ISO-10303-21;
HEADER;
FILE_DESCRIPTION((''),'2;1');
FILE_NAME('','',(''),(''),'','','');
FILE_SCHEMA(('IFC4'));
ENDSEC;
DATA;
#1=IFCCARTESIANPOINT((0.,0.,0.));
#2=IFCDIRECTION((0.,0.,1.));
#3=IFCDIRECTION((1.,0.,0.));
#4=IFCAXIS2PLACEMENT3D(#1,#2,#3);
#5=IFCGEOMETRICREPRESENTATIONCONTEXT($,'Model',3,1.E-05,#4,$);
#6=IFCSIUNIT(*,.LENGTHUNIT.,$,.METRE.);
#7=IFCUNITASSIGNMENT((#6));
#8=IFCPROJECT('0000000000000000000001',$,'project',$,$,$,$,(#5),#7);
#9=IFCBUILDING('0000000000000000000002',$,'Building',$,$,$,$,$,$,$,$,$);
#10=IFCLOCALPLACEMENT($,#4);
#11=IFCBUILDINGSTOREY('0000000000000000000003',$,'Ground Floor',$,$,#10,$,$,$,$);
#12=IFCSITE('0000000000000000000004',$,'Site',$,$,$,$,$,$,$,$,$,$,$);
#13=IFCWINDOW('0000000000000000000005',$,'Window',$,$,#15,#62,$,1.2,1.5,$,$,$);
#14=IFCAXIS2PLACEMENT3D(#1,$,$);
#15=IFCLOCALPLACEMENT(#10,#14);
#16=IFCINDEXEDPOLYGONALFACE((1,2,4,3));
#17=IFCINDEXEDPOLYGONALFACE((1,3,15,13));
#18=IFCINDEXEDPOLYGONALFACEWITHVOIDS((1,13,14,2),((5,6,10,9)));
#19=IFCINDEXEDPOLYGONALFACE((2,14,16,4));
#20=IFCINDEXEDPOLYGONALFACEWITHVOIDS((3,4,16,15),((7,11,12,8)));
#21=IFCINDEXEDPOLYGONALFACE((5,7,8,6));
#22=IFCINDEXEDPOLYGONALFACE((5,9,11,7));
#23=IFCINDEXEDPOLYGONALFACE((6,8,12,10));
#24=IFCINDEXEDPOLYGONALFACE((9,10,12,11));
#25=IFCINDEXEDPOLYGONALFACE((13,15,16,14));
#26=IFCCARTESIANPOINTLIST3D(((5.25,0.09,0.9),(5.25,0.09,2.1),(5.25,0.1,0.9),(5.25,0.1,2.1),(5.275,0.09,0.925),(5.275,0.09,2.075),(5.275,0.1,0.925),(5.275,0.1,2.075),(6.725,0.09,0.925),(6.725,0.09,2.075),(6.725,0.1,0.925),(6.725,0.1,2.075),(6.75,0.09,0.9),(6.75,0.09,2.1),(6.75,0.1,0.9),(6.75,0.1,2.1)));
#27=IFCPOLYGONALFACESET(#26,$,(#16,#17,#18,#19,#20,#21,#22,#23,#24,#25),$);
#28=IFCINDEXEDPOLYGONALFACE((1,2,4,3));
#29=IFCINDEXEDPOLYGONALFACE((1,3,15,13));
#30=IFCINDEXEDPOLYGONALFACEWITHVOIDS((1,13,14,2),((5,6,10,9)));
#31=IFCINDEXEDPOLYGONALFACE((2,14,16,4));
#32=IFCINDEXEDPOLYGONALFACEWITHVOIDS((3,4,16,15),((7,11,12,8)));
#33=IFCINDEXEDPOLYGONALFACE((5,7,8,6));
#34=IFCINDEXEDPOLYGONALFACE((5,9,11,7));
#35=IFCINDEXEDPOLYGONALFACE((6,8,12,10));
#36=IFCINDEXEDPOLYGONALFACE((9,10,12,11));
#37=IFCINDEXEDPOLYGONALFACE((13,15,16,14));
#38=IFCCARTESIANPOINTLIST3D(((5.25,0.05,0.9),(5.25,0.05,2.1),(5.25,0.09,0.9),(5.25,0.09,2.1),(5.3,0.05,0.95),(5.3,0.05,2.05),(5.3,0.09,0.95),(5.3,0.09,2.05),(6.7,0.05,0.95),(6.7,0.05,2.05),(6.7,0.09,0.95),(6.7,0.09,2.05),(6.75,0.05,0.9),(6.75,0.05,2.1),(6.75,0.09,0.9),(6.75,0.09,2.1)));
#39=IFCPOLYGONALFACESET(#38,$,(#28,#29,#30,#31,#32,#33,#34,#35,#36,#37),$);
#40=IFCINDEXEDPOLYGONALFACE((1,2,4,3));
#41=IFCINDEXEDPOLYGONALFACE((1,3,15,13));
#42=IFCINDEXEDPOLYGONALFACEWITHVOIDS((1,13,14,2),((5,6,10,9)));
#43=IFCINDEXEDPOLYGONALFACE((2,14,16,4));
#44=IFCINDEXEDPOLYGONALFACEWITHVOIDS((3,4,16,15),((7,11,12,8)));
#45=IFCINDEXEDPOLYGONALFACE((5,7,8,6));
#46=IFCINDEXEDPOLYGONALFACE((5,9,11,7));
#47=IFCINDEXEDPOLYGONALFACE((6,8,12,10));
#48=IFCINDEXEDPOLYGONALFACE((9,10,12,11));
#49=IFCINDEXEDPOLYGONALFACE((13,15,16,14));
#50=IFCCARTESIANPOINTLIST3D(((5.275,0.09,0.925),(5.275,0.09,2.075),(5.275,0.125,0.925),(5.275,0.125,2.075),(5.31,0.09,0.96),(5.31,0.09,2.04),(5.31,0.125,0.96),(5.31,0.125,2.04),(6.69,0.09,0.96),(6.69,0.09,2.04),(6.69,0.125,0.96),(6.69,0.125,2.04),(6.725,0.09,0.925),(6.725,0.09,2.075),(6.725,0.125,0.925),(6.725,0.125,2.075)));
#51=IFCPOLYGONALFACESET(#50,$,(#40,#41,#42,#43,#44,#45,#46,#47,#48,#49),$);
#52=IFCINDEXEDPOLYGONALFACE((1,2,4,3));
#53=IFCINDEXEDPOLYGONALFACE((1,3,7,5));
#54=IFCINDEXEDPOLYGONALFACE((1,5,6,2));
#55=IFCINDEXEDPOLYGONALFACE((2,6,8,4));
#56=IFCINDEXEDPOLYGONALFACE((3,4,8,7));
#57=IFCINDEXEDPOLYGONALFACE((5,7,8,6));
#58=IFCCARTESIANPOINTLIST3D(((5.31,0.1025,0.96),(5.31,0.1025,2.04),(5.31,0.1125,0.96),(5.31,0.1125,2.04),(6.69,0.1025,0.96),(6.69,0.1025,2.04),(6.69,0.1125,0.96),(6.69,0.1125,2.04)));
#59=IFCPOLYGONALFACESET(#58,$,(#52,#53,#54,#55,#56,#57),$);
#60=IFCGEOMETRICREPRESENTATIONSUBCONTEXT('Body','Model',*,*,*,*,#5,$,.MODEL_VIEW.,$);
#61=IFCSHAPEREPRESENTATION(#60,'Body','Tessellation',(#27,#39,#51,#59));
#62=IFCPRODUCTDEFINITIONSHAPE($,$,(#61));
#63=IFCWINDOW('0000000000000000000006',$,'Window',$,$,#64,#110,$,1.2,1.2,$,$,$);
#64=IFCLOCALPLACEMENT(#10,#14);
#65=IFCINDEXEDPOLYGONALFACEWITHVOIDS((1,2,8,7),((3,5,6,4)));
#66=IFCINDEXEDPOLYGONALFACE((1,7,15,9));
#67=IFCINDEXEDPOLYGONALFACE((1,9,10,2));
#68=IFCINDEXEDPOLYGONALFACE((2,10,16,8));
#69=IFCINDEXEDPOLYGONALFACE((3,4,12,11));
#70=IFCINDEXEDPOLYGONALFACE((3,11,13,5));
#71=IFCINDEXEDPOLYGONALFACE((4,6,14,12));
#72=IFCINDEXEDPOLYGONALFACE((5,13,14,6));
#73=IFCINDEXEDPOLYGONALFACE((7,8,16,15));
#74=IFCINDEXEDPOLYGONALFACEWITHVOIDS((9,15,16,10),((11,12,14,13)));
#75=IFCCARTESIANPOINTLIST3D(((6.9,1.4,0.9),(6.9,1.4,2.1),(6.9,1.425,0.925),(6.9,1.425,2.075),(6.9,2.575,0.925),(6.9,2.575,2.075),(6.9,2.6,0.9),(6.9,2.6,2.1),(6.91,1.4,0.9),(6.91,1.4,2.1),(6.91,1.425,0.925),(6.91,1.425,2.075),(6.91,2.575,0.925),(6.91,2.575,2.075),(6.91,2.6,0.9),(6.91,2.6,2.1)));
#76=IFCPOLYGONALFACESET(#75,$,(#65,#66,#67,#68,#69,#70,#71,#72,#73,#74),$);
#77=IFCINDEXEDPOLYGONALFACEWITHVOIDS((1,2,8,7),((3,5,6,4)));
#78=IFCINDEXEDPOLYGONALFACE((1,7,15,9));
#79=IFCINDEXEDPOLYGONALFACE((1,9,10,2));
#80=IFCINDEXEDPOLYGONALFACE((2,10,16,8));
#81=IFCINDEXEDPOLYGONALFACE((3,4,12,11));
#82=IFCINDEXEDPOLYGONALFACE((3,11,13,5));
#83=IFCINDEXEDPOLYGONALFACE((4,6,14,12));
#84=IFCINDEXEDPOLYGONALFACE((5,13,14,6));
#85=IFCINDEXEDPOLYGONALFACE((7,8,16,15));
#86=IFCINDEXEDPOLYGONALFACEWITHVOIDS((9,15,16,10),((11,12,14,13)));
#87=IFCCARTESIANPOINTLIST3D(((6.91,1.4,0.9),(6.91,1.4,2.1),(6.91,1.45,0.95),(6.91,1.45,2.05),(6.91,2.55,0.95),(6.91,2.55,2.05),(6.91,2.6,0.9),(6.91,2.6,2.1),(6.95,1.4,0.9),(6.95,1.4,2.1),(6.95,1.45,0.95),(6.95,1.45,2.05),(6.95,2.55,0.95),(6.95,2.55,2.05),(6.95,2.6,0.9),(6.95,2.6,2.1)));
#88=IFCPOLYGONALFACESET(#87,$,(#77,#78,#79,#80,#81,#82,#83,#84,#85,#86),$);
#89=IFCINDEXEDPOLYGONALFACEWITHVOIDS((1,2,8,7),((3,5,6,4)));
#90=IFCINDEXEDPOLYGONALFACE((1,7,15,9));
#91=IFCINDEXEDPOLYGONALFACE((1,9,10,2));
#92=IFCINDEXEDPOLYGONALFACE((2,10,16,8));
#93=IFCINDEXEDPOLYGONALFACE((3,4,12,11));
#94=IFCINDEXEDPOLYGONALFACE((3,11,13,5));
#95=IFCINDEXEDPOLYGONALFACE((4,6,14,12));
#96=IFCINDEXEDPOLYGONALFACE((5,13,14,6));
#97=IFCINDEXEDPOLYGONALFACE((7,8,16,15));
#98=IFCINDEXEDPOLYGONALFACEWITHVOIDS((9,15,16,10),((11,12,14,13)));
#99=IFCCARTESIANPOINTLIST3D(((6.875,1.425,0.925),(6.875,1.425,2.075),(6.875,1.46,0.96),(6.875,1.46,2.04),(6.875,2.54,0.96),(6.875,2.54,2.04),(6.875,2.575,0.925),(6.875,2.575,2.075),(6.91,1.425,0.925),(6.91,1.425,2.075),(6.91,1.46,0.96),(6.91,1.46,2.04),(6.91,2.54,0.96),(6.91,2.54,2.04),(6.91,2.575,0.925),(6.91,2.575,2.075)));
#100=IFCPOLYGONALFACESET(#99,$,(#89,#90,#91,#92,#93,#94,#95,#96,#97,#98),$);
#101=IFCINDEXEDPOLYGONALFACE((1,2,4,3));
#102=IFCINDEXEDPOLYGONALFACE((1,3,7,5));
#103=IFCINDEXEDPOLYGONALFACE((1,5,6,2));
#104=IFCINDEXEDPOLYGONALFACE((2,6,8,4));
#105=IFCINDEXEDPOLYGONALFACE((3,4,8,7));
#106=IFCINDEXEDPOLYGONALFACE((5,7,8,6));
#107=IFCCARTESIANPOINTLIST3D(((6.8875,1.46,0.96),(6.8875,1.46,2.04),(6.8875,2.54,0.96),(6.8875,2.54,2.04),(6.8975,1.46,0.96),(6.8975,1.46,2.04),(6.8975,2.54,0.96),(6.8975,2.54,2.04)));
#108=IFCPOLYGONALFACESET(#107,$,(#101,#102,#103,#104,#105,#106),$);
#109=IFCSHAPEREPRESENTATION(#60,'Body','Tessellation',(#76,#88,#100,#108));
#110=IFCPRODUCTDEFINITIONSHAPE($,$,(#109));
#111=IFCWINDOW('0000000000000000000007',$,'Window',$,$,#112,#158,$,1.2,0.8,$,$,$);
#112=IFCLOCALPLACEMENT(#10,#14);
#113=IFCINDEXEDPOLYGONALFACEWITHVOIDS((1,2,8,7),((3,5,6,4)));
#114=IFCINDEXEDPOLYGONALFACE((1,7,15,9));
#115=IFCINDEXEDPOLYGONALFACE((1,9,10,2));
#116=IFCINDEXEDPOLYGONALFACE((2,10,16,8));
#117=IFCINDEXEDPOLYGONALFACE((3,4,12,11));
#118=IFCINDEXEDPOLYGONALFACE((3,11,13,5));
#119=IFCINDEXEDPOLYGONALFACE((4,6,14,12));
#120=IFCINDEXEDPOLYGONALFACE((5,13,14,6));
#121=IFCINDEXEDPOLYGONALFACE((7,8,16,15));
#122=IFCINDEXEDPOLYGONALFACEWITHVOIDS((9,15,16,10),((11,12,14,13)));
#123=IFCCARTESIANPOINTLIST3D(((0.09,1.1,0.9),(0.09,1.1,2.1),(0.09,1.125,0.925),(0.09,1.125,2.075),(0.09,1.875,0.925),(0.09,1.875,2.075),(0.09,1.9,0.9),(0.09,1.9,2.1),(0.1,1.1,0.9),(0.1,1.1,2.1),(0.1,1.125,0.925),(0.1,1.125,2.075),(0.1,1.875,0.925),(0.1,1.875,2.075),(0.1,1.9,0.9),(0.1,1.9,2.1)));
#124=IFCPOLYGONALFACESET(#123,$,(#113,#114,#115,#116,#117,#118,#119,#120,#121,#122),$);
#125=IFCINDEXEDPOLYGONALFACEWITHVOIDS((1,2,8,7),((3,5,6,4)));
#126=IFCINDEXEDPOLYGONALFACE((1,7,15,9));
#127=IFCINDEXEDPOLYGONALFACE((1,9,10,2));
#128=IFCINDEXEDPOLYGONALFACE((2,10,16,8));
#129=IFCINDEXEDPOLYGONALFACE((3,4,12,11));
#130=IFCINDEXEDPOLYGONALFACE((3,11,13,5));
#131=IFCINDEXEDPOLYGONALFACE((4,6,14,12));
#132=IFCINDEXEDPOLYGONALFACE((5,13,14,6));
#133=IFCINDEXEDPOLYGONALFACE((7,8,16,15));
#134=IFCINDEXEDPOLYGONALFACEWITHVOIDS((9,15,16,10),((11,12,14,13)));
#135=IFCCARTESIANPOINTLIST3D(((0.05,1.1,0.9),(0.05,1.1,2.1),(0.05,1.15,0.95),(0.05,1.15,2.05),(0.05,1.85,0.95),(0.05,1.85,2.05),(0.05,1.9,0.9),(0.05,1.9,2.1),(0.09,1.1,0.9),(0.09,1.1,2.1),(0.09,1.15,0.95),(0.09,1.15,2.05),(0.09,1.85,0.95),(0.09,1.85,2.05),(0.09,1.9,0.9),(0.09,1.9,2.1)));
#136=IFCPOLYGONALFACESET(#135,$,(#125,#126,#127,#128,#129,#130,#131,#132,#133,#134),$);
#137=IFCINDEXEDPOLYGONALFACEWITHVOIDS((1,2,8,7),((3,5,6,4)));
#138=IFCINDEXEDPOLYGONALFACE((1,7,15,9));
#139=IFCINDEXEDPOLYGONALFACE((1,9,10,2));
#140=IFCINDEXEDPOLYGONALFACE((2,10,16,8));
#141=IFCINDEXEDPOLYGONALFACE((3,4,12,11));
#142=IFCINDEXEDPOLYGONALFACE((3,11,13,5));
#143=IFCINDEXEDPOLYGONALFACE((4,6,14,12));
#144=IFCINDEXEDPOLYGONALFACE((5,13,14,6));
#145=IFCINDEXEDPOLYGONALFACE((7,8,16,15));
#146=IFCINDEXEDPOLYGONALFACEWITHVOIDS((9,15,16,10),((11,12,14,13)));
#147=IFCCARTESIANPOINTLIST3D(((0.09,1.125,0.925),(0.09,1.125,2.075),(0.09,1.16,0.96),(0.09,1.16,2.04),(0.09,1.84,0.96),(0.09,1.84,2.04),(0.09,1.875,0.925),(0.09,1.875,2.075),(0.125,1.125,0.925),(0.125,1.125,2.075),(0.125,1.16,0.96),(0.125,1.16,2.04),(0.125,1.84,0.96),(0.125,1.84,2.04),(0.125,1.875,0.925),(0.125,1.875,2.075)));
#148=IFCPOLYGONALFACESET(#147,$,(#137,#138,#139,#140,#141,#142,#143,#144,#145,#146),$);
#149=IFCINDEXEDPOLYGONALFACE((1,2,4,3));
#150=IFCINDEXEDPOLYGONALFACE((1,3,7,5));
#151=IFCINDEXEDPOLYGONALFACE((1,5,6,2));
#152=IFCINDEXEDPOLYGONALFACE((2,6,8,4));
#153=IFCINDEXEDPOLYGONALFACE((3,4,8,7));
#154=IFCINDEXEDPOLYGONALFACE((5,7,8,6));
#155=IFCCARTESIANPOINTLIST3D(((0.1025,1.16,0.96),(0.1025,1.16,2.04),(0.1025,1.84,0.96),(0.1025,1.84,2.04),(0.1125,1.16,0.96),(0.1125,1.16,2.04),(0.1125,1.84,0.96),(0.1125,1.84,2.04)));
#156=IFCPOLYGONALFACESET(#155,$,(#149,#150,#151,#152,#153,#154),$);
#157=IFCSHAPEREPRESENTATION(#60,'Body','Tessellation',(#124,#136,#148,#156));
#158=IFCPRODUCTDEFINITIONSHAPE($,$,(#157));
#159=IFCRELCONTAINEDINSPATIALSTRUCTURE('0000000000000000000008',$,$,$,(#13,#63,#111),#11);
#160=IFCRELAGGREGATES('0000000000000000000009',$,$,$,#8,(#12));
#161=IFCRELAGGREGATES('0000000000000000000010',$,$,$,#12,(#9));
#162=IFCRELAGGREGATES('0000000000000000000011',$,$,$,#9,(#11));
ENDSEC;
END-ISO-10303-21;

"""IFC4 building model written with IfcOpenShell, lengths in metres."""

from ifc_helpers import new_model, si_unit, frame, origin_with_axes, place, context, subcontext, project, spatial, line, indexed_curve, outline, extrude, element, save


model = new_model("IFC4")

# Units and contexts
model_context = context("Model", 3, precision=1e-05, world=origin_with_axes())
body_context = subcontext(model_context, "Body", "Model", "MODEL_VIEW")
ifc_project = project(units=[si_unit("LENGTHUNIT", "METRE")], contexts=[model_context])

# Site, building, storey
site = spatial("IfcSite", under=ifc_project, Name="Site")
building = spatial("IfcBuilding", under=site, Name="Building")
storey_placement = place(None, origin_with_axes())
storey = spatial("IfcBuildingStorey", under=building, at=storey_placement, Name="Ground Floor")

# Windows
window_1_placement = place(storey_placement, frame((5.25, 0.0, 0.9), z_axis=(0.0, 0.0, 1.0), x_axis=(1.0, 0.0, 0.0)))
element("IfcWindow", 1, at=window_1_placement, inside=storey, Name="Window", OverallHeight=1.2, OverallWidth=1.5, context=body_context, shape_type="SweptSolid", body=[
    extrude(outline(indexed_curve([(0.0, 0.0), (1.5, 0.0), (1.5, 1.2), (0.0, 1.2)], segments=[line(1, 2, 3, 4, 1)]), holes=[indexed_curve([(0.025, 0.025), (1.475, 0.025), (1.475, 1.175), (0.025, 1.175)], segments=[line(1, 2, 3, 4, 1)])]), frame((0.0, 0.09, 0.0), z_axis=(0.0, -1.0, 0.0), x_axis=(1.0, 0.0, 0.0)), (0.0, 0.0, -1.0), 0.01),
    extrude(outline(indexed_curve([(0.0, 0.0), (1.5, 0.0), (1.5, 1.2), (0.0, 1.2)], segments=[line(1, 2, 3, 4, 1)]), holes=[indexed_curve([(0.05, 0.05), (1.45, 0.05), (1.45, 1.15), (0.05, 1.15)], segments=[line(1, 2, 3, 4, 1)])]), frame((0.0, 0.05, 0.0), z_axis=(0.0, -1.0, 0.0), x_axis=(1.0, 0.0, 0.0)), (0.0, 0.0, -1.0), 0.04),
    extrude(outline(indexed_curve([(0.0, 0.0), (1.45, 0.0), (1.45, 1.15), (0.0, 1.15)], segments=[line(1, 2, 3, 4, 1)]), holes=[indexed_curve([(0.035, 0.035), (1.415, 0.035), (1.415, 1.115), (0.035, 1.115)], segments=[line(1, 2, 3, 4, 1)])]), frame((0.025, 0.09, 0.025), z_axis=(0.0, -1.0, 0.0), x_axis=(1.0, 0.0, 0.0)), (0.0, 0.0, -1.0), 0.035),
    extrude(outline(indexed_curve([(0.035, 0.035), (1.415, 0.035), (1.415, 1.115), (0.035, 1.115)], segments=[line(1, 2, 3, 4, 1)])), frame((0.025, 0.1025, 0.025), z_axis=(0.0, -1.0, 0.0), x_axis=(1.0, 0.0, 0.0)), (0.0, 0.0, -1.0), 0.01),
])
window_2_placement = place(storey_placement, frame((7.0, 1.4, 0.9), z_axis=(0.0, 0.0, 1.0), x_axis=(0.0, 1.0, 0.0)))
element("IfcWindow", 2, at=window_2_placement, inside=storey, Name="Window", OverallHeight=1.2, OverallWidth=1.2, context=body_context, shape_type="SweptSolid", body=[
    extrude(outline(indexed_curve([(0.0, 0.0), (1.2, 0.0), (1.2, 1.2), (0.0, 1.2)], segments=[line(1, 2, 3, 4, 1)]), holes=[indexed_curve([(0.025, 0.025), (1.175, 0.025), (1.175, 1.175), (0.025, 1.175)], segments=[line(1, 2, 3, 4, 1)])]), frame((0.0, 0.09, 0.0), z_axis=(0.0, -1.0, 0.0), x_axis=(1.0, 0.0, 0.0)), (0.0, 0.0, -1.0), 0.01),
    extrude(outline(indexed_curve([(0.0, 0.0), (1.2, 0.0), (1.2, 1.2), (0.0, 1.2)], segments=[line(1, 2, 3, 4, 1)]), holes=[indexed_curve([(0.05, 0.05), (1.15, 0.05), (1.15, 1.15), (0.05, 1.15)], segments=[line(1, 2, 3, 4, 1)])]), frame((0.0, 0.05, 0.0), z_axis=(0.0, -1.0, 0.0), x_axis=(1.0, 0.0, 0.0)), (0.0, 0.0, -1.0), 0.04),
    extrude(outline(indexed_curve([(0.0, 0.0), (1.15, 0.0), (1.15, 1.15), (0.0, 1.15)], segments=[line(1, 2, 3, 4, 1)]), holes=[indexed_curve([(0.035, 0.035), (1.115, 0.035), (1.115, 1.115), (0.035, 1.115)], segments=[line(1, 2, 3, 4, 1)])]), frame((0.025, 0.09, 0.025), z_axis=(0.0, -1.0, 0.0), x_axis=(1.0, 0.0, 0.0)), (0.0, 0.0, -1.0), 0.035),
    extrude(outline(indexed_curve([(0.035, 0.035), (1.115, 0.035), (1.115, 1.115), (0.035, 1.115)], segments=[line(1, 2, 3, 4, 1)])), frame((0.025, 0.1025, 0.025), z_axis=(0.0, -1.0, 0.0), x_axis=(1.0, 0.0, 0.0)), (0.0, 0.0, -1.0), 0.01),
])
window_3_placement = place(storey_placement, frame((0.0, 1.9, 0.9), z_axis=(0.0, 0.0, 1.0), x_axis=(0.0, -1.0, 0.0)))
element("IfcWindow", 3, at=window_3_placement, inside=storey, Name="Window", OverallHeight=1.2, OverallWidth=0.8, context=body_context, shape_type="SweptSolid", body=[
    extrude(outline(indexed_curve([(0.0, 0.0), (0.8, 0.0), (0.8, 1.2), (0.0, 1.2)], segments=[line(1, 2, 3, 4, 1)]), holes=[indexed_curve([(0.025, 0.025), (0.775, 0.025), (0.775, 1.175), (0.025, 1.175)], segments=[line(1, 2, 3, 4, 1)])]), frame((0.0, 0.09, 0.0), z_axis=(0.0, -1.0, 0.0), x_axis=(1.0, 0.0, 0.0)), (0.0, 0.0, -1.0), 0.01),
    extrude(outline(indexed_curve([(0.0, 0.0), (0.8, 0.0), (0.8, 1.2), (0.0, 1.2)], segments=[line(1, 2, 3, 4, 1)]), holes=[indexed_curve([(0.05, 0.05), (0.75, 0.05), (0.75, 1.15), (0.05, 1.15)], segments=[line(1, 2, 3, 4, 1)])]), frame((0.0, 0.05, 0.0), z_axis=(0.0, -1.0, 0.0), x_axis=(1.0, 0.0, 0.0)), (0.0, 0.0, -1.0), 0.04),
    extrude(outline(indexed_curve([(0.0, 0.0), (0.75, 0.0), (0.75, 1.15), (0.0, 1.15)], segments=[line(1, 2, 3, 4, 1)]), holes=[indexed_curve([(0.035, 0.035), (0.715, 0.035), (0.715, 1.115), (0.035, 1.115)], segments=[line(1, 2, 3, 4, 1)])]), frame((0.025, 0.09, 0.025), z_axis=(0.0, -1.0, 0.0), x_axis=(1.0, 0.0, 0.0)), (0.0, 0.0, -1.0), 0.035),
    extrude(outline(indexed_curve([(0.035, 0.035), (0.715, 0.035), (0.715, 1.115), (0.035, 1.115)], segments=[line(1, 2, 3, 4, 1)])), frame((0.025, 0.1025, 0.025), z_axis=(0.0, -1.0, 0.0), x_axis=(1.0, 0.0, 0.0)), (0.0, 0.0, -1.0), 0.01),
])

save(model, "model.ifc")
